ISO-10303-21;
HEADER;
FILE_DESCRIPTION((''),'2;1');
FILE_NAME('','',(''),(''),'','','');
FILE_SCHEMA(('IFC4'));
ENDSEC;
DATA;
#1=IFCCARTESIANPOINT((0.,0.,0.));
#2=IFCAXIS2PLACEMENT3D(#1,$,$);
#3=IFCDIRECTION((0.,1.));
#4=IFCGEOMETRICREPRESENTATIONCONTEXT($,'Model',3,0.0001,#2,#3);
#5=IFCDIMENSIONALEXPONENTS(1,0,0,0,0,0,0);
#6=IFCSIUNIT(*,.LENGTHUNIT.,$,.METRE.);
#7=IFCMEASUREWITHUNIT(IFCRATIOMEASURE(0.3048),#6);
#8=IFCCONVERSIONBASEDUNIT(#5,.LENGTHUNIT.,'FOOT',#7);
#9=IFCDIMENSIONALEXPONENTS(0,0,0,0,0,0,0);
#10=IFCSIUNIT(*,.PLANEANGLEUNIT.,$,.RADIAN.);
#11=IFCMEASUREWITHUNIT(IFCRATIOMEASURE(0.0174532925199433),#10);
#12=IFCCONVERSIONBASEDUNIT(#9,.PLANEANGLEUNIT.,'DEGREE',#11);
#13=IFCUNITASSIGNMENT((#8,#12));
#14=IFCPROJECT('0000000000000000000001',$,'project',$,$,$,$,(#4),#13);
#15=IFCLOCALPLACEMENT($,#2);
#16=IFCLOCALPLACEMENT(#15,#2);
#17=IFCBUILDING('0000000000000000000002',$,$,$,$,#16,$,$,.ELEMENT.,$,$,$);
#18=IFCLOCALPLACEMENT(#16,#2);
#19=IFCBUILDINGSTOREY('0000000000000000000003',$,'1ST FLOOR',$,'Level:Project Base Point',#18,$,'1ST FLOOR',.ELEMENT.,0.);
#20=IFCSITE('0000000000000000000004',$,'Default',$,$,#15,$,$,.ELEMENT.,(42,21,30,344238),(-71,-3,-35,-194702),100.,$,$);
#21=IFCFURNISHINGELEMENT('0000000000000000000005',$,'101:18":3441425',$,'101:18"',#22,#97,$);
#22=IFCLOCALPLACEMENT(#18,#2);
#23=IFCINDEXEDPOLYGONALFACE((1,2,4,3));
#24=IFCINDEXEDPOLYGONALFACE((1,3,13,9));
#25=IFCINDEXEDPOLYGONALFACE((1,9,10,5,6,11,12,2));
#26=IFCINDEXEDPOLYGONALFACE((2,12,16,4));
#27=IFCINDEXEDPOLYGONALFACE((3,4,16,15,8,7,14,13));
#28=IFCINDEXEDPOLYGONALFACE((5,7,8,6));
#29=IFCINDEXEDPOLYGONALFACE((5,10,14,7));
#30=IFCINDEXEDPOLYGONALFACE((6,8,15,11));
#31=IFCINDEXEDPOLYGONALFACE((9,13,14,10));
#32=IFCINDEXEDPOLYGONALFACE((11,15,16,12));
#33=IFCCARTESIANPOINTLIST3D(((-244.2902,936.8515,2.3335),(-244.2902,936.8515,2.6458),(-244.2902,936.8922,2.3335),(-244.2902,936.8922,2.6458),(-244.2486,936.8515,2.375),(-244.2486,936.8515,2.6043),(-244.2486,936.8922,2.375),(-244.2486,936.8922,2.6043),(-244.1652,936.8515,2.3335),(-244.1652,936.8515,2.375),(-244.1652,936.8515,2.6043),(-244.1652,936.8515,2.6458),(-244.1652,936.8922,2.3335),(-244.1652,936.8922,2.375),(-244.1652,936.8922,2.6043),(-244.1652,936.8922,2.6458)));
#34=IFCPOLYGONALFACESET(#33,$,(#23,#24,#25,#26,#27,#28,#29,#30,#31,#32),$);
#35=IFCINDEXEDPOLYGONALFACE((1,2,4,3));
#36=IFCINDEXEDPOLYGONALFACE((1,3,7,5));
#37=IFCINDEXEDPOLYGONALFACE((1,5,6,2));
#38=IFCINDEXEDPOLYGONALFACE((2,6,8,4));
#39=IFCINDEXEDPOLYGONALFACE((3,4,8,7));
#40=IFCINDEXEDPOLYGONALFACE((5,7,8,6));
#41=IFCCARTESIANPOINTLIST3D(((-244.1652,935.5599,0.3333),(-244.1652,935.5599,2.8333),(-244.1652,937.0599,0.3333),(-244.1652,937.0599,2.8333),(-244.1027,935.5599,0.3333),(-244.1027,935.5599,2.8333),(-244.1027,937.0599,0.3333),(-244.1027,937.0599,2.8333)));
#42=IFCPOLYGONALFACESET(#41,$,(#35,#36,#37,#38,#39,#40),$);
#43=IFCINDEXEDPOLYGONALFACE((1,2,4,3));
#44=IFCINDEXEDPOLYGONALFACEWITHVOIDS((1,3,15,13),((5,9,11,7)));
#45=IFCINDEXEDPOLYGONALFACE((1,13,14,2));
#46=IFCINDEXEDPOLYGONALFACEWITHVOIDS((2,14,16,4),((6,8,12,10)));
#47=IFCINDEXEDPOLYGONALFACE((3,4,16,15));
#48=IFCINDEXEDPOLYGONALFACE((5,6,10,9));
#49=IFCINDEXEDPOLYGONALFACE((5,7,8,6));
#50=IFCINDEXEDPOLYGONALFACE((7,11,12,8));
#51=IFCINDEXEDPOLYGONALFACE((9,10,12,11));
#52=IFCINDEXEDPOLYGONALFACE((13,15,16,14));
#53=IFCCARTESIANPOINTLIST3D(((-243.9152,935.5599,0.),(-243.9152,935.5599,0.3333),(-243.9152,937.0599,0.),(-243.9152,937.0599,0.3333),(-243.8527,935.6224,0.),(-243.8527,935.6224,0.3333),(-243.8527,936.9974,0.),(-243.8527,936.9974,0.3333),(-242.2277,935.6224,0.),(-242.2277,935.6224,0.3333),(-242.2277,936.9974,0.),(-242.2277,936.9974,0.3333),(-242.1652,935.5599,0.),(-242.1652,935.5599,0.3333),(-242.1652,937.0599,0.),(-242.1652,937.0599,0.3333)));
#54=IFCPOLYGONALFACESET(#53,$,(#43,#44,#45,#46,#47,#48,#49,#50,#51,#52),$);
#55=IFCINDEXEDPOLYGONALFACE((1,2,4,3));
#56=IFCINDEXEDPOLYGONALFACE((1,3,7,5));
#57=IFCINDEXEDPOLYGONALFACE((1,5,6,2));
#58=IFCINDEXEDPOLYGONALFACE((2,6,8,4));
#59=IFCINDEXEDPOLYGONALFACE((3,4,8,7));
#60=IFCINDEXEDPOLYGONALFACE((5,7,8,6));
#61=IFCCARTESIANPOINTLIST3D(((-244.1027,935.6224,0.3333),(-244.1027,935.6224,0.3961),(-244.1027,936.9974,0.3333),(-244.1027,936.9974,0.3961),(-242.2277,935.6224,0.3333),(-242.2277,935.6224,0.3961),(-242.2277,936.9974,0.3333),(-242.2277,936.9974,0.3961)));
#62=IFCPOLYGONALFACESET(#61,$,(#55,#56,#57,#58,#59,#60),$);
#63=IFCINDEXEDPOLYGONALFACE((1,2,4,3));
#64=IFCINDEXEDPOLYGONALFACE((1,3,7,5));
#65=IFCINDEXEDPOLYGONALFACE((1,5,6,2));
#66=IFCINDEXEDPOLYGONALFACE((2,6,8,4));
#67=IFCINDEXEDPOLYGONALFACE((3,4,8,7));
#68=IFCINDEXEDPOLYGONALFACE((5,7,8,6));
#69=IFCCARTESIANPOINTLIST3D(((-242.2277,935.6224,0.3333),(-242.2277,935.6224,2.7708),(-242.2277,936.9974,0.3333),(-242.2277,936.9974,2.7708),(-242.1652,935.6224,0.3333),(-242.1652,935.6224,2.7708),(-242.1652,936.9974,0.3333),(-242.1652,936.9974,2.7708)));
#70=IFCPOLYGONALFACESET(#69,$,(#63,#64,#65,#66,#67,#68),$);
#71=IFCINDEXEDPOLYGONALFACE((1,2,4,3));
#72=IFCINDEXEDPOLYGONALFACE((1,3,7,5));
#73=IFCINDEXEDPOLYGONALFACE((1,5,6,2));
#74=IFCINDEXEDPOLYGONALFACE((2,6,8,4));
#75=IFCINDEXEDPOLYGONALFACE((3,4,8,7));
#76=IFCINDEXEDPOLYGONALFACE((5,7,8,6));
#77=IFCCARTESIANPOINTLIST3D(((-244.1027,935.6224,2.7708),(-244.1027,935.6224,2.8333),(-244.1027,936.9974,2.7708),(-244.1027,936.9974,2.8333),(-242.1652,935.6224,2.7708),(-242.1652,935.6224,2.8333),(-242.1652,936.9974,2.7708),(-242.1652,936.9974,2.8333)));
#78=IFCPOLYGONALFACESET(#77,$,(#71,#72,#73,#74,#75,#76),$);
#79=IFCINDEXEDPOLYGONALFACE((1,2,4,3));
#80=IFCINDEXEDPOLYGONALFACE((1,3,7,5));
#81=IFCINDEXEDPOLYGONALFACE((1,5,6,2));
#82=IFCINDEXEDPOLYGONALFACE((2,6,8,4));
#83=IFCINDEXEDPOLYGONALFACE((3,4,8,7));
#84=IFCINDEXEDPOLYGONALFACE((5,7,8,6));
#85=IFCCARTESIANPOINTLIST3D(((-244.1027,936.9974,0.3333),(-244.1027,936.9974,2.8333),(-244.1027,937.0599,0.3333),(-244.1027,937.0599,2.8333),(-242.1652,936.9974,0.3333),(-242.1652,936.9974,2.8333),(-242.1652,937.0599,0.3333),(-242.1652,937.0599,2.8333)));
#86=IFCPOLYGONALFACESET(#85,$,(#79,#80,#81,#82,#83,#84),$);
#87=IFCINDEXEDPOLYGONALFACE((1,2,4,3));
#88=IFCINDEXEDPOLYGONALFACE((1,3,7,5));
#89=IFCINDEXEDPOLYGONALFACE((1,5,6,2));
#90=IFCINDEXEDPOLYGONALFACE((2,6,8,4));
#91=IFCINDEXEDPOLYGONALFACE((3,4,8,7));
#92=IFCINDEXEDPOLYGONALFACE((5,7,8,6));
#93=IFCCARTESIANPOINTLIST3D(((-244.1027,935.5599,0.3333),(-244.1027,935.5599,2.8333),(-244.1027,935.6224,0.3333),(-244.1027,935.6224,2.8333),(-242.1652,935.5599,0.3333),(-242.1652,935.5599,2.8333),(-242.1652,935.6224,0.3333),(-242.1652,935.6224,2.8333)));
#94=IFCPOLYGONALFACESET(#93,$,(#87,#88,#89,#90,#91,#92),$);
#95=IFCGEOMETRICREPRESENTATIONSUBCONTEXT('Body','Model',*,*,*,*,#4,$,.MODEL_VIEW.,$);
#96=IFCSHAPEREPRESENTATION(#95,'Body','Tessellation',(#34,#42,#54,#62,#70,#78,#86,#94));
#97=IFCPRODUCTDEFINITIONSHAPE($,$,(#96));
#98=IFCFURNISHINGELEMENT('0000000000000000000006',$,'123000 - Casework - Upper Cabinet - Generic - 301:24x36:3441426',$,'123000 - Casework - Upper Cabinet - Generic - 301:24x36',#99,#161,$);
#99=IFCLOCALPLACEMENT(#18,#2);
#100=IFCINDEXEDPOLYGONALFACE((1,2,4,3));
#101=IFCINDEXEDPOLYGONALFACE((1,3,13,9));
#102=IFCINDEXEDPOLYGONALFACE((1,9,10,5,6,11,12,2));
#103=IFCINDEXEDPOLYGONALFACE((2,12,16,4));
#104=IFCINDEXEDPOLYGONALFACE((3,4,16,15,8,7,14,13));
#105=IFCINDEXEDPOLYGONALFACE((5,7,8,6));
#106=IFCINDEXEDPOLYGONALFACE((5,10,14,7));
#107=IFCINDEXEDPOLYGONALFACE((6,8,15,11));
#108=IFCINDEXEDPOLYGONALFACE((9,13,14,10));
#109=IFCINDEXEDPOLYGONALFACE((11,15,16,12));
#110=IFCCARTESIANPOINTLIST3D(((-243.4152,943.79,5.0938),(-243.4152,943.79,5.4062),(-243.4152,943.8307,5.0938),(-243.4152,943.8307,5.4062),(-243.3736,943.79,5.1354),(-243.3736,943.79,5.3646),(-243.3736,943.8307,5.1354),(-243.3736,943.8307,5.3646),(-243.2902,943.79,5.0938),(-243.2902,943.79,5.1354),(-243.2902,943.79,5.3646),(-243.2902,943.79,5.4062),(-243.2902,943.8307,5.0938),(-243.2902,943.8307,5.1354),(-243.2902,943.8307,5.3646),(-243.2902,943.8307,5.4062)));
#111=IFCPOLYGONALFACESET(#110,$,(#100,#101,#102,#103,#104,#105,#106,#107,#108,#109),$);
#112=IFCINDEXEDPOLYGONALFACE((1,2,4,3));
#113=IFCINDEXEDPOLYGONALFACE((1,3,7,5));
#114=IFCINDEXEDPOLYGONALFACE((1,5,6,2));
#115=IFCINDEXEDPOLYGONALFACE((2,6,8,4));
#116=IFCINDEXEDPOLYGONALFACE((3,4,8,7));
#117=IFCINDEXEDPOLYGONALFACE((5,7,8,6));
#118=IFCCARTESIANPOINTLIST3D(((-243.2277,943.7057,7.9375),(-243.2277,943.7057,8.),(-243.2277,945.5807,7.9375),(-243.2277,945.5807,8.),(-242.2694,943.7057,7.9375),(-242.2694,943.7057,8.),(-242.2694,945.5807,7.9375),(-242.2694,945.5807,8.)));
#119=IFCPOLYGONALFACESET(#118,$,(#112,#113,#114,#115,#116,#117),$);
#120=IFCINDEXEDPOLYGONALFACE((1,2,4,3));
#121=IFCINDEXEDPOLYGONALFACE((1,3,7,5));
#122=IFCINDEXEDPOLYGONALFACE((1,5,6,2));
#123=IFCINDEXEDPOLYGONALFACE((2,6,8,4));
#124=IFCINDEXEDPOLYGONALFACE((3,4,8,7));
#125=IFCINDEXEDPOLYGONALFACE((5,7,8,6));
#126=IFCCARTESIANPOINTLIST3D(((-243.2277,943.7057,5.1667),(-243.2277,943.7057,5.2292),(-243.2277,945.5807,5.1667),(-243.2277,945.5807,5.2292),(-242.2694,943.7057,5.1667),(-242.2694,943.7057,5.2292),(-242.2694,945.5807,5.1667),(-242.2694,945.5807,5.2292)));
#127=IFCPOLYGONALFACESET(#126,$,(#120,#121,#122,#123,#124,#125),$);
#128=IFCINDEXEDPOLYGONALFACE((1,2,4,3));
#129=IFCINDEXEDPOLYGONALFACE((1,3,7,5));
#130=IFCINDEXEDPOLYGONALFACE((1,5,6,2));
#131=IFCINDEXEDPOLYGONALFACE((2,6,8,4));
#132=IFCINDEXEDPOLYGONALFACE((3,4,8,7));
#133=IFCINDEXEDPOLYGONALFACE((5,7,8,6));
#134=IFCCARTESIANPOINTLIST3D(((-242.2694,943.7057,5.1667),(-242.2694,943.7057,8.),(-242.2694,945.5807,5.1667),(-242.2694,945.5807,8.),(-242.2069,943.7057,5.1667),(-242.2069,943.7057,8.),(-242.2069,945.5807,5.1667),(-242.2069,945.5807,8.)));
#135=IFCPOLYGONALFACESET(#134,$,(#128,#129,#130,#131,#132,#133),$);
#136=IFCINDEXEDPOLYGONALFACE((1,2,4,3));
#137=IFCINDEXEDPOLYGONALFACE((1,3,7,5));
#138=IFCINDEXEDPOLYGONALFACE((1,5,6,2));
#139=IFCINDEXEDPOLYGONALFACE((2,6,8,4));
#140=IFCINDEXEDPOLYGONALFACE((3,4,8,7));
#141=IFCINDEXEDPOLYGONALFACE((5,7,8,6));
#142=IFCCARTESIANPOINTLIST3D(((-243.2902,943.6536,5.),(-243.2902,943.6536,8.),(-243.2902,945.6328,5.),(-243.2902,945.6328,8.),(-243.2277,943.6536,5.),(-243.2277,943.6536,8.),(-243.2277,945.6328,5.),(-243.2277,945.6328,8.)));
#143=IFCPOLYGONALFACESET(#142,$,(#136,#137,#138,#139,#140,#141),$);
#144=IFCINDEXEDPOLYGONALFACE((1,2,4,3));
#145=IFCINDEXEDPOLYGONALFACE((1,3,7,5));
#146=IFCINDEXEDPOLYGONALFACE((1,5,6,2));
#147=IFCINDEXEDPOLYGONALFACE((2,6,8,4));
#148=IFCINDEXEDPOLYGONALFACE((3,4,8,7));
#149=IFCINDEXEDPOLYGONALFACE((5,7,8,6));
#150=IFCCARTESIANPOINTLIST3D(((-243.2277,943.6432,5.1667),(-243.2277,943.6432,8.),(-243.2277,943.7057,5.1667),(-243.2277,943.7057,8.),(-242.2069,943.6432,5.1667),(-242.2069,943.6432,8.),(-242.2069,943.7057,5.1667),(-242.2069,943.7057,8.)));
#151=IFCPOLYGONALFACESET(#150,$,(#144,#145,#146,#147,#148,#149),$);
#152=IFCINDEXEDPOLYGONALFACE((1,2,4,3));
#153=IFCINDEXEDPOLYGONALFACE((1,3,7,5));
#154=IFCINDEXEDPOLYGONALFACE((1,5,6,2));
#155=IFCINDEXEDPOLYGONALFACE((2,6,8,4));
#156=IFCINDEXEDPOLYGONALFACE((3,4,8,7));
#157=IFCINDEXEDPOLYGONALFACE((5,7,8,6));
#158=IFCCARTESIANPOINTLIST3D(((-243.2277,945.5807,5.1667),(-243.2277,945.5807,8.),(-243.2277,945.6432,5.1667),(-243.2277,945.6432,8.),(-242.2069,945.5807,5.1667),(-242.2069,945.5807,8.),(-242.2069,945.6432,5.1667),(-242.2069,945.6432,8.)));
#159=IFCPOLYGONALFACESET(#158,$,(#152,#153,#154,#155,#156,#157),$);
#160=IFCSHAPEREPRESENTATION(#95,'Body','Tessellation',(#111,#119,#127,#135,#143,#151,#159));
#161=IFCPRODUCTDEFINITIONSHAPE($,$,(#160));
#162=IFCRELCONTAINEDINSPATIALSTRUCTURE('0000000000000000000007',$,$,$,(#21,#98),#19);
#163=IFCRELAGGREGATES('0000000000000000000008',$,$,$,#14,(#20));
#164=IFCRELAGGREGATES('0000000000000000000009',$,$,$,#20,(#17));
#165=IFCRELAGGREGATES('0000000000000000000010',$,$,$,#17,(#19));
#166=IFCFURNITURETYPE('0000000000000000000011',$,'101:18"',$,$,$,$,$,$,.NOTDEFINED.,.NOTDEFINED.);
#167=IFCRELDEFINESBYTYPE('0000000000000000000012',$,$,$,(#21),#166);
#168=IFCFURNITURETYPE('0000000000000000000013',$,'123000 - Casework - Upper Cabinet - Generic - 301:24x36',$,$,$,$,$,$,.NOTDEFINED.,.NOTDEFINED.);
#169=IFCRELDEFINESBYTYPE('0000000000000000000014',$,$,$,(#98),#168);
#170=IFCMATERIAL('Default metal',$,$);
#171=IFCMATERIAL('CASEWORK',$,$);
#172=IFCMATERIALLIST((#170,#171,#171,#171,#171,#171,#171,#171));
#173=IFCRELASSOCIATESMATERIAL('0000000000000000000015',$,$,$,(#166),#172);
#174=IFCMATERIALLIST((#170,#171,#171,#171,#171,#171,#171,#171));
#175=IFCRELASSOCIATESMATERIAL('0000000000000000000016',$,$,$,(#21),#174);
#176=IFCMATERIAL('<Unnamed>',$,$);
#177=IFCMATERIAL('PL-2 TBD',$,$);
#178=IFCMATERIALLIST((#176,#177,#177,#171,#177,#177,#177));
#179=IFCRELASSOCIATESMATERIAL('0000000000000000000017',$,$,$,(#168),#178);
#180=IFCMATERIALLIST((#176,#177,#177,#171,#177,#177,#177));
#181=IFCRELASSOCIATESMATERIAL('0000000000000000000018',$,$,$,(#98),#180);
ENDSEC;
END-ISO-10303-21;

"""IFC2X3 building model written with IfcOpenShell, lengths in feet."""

from ifc_helpers import new_model, entity, si_unit, converted_unit, direction, frame, frame_2d, origin, origin_2d_with_axis, place, context, subcontext, project, spatial, polyline, rectangle, outline, extrude, source, transform, mapped, material, material_list, type_object, type_shapes, element, save


model = new_model("IFC2X3")

# Units and contexts
model_context = context("Model", 3, precision=0.0001, world=origin(), true_north=direction((0.0, 1.0)))
body_context = subcontext(model_context, "Body", "Model", "MODEL_VIEW")
ifc_project = project(units=[converted_unit("LENGTHUNIT", "FOOT", entity("IfcRatioMeasure", 0.3048), si_unit("LENGTHUNIT", "METRE"), dimensions=[1, 0, 0, 0, 0, 0, 0]), converted_unit("PLANEANGLEUNIT", "DEGREE", entity("IfcRatioMeasure", 0.0174532925199433), si_unit("PLANEANGLEUNIT", "RADIAN"), dimensions=[0, 0, 0, 0, 0, 0, 0])], contexts=[model_context])

# Site, building, storey
site_placement = place(None, origin())
site = spatial("IfcSite", under=ifc_project, at=site_placement, Name="Default", CompositionType="ELEMENT", RefLatitude=(42, 21, 30, 344238), RefLongitude=(-71, -3, -35, -194702), RefElevation=100.0)
building_placement = place(site_placement, origin())
building = spatial("IfcBuilding", under=site, at=building_placement, CompositionType="ELEMENT")
storey_placement = place(building_placement, origin())
storey = spatial("IfcBuildingStorey", under=building, at=storey_placement, Name="1ST FLOOR", ObjectType="Level:Project Base Point", LongName="1ST FLOOR", CompositionType="ELEMENT", Elevation=0.0)

# Furnishing elements
ifc_material_1 = material(Name="Default metal")
ifc_material_2 = material(Name="CASEWORK")
ifc_material_3 = material(Name="<Unnamed>")
ifc_material_list_1 = material_list([ifc_material_1, ifc_material_2, ifc_material_2, ifc_material_2, ifc_material_2, ifc_material_2, ifc_material_2, ifc_material_2])
ifc_material_list_2 = material_list([ifc_material_1, ifc_material_2, ifc_material_2, ifc_material_2, ifc_material_2, ifc_material_2, ifc_material_2, ifc_material_2])
furniture_type_1 = type_object("IfcFurnitureType", Name="101:18\"", material=ifc_material_list_2)
shared_shape_1 = source(origin(), body_context, "Body", "SweptSolid", [
    extrude(outline(polyline([(-0.0521, -0.1146), (-0.0521, -0.1562), (0.0729, -0.1562), (0.0729, 0.1562), (-0.0521, 0.1562), (-0.0521, 0.1146), (0.0313, 0.1146), (0.0313, -0.1146), (-0.0521, -0.1146)])), frame((0.3531, 2.0521, 2.4896), z_axis=(-1.0, 0.0, 0.0), x_axis=(0.0, 1.0, 0.0)), (0.0, 0.0, -1.0), 0.0407),
    extrude(rectangle(XDim=1.5, YDim=0.0625, at=frame_2d((0.0, 0.0), x_axis=(1.0, 0.0))), frame((-0.1885, 1.9688, 0.3333), z_axis=(0.0, 0.0, 1.0), x_axis=(-1.0, 0.0, 0.0)), (0.0, 0.0, 1.0), 2.5),
    extrude(outline(polyline([(-0.875, -0.75), (0.875, -0.75), (0.875, 0.75), (-0.875, 0.75), (-0.875, -0.75)]), holes=[polyline([(-0.8125, -0.6875), (-0.8125, 0.6875), (0.8125, 0.6875), (0.8125, -0.6875), (-0.8125, -0.6875)])]), frame((-0.1885, 0.875, 0.0), z_axis=(0.0, 0.0, 1.0), x_axis=(0.0, -1.0, 0.0)), (0.0, 0.0, 1.0), 0.3333),
    extrude(rectangle(XDim=1.875, YDim=1.375, at=frame_2d((0.0, 0.0), x_axis=(1.0, 0.0))), frame((-0.1885, 1.0, 0.3333), z_axis=(0.0, 0.0, 1.0), x_axis=(0.0, 1.0, 0.0)), (0.0, 0.0, 1.0), 0.0627),
    extrude(rectangle(XDim=1.375, YDim=0.0625, at=origin_2d_with_axis()), frame((-0.1885, 0.0312, 0.3333), z_axis=(0.0, 0.0, 1.0), x_axis=(-1.0, 0.0, 0.0)), (0.0, 0.0, 1.0), 2.4375),
    extrude(rectangle(XDim=1.9375, YDim=1.375, at=origin_2d_with_axis()), frame((-0.1885, 0.9688, 2.7708), z_axis=(0.0, 0.0, 1.0), x_axis=(0.0, 1.0, 0.0)), (0.0, 0.0, 1.0), 0.0625),
    extrude(rectangle(XDim=1.9375, YDim=0.0625, at=frame_2d((0.0, 0.0), x_axis=(1.0, 0.0))), frame((0.5302, 0.9687, 0.3333), z_axis=(0.0, 0.0, 1.0), x_axis=(0.0, -1.0, 0.0)), (0.0, 0.0, 1.0), 2.5),
    extrude(rectangle(XDim=1.9375, YDim=0.0625, at=origin_2d_with_axis()), frame((-0.9073, 0.9687, 0.3333), z_axis=(0.0, 0.0, 1.0), x_axis=(0.0, -1.0, 0.0)), (0.0, 0.0, 1.0), 2.5),
])
type_shapes(furniture_type_1, [shared_shape_1])
furnishing_1_placement = place(storey_placement, frame((-242.1652, 936.4984, 0.0), z_axis=(0.0, 0.0, 1.0), x_axis=(0.0, 1.0, 0.0)))
element("IfcFurnishingElement", 1, at=furnishing_1_placement, inside=storey, type_object=furniture_type_1, material=ifc_material_list_1, Name="101:18\":3441425", ObjectType="101:18\"", context=body_context, shape_type="MappedRepresentation", body=[
    mapped(shared_shape_1, transform((0.0, 0.0, 0.0), scale=1.0)),
])
ifc_material_4 = material(Name="PL-2 TBD")
ifc_material_list_3 = material_list([ifc_material_3, ifc_material_4, ifc_material_4, ifc_material_2, ifc_material_4, ifc_material_4, ifc_material_4])
ifc_material_list_4 = material_list([ifc_material_3, ifc_material_4, ifc_material_4, ifc_material_2, ifc_material_4, ifc_material_4, ifc_material_4])
furniture_type_2 = type_object("IfcFurnitureType", Name="123000 - Casework - Upper Cabinet - Generic - 301:24x36", material=ifc_material_list_4)
shared_shape_2 = source(origin(), body_context, "Body", "SweptSolid", [
    extrude(outline(polyline([(-0.0521, -0.1146), (-0.0521, -0.1562), (0.0729, -0.1562), (0.0729, 0.1562), (-0.0521, 0.1562), (-0.0521, 0.1146), (0.0313, 0.1146), (0.0313, -0.1146), (-0.0521, -0.1146)])), frame((0.1468, 1.1354, 0.25), z_axis=(-1.0, 0.0, 0.0), x_axis=(0.0, 1.0, 0.0)), (0.0, 0.0, -1.0), 0.0407),
    extrude(rectangle(XDim=0.9583, YDim=1.875, at=frame_2d((0.0, 0.0), x_axis=(1.0, 0.0))), frame((1.0, 0.5417, 2.9375), z_axis=(0.0, 0.0, 1.0), x_axis=(0.0, 1.0, 0.0)), (0.0, 0.0, 1.0), 0.0625),
    extrude(rectangle(XDim=0.9583, YDim=1.875, at=frame_2d((0.0, 0.0), x_axis=(1.0, 0.0))), frame((1.0, 0.5417, 0.1667), z_axis=(0.0, 0.0, 1.0), x_axis=(0.0, 1.0, 0.0)), (0.0, 0.0, 1.0), 0.0625),
    extrude(rectangle(XDim=1.875, YDim=0.0625, at=origin_2d_with_axis()), frame((1.0, 0.0313, 0.1667), z_axis=(0.0, 0.0, 1.0), x_axis=(-1.0, 0.0, 0.0)), (0.0, 0.0, 1.0), 2.8333),
    extrude(rectangle(XDim=1.9792, YDim=0.0625, at=frame_2d((0.0, 0.0), x_axis=(1.0, 0.0))), frame((1.0, 1.0521, 0.0)), (0.0, 0.0, 1.0), 3.0),
    extrude(rectangle(XDim=1.0208, YDim=0.0625, at=origin_2d_with_axis()), frame((0.0312, 0.5104, 0.1667), z_axis=(0.0, 0.0, 1.0), x_axis=(0.0, 1.0, 0.0)), (0.0, 0.0, 1.0), 2.8333),
    extrude(rectangle(XDim=1.0208, YDim=0.0625, at=frame_2d((0.0, 0.0), x_axis=(1.0, 0.0))), frame((1.9688, 0.5104, 0.1667), z_axis=(0.0, 0.0, 1.0), x_axis=(0.0, 1.0, 0.0)), (0.0, 0.0, 1.0), 2.8333),
])
type_shapes(furniture_type_2, [shared_shape_2])
furnishing_2_placement = place(storey_placement, frame((-242.2069, 943.6432, 5.0), z_axis=(0.0, 0.0, 1.0), x_axis=(0.0, 1.0, 0.0)))
element("IfcFurnishingElement", 2, at=furnishing_2_placement, inside=storey, type_object=furniture_type_2, material=ifc_material_list_3, Name="123000 - Casework - Upper Cabinet - Generic - 301:24x36:3441426", ObjectType="123000 - Casework - Upper Cabinet - Generic - 301:24x36", context=body_context, shape_type="MappedRepresentation", body=[
    mapped(shared_shape_2, transform((0.0, 0.0, 0.0), scale=1.0)),
])

save(model, "model.ifc")
